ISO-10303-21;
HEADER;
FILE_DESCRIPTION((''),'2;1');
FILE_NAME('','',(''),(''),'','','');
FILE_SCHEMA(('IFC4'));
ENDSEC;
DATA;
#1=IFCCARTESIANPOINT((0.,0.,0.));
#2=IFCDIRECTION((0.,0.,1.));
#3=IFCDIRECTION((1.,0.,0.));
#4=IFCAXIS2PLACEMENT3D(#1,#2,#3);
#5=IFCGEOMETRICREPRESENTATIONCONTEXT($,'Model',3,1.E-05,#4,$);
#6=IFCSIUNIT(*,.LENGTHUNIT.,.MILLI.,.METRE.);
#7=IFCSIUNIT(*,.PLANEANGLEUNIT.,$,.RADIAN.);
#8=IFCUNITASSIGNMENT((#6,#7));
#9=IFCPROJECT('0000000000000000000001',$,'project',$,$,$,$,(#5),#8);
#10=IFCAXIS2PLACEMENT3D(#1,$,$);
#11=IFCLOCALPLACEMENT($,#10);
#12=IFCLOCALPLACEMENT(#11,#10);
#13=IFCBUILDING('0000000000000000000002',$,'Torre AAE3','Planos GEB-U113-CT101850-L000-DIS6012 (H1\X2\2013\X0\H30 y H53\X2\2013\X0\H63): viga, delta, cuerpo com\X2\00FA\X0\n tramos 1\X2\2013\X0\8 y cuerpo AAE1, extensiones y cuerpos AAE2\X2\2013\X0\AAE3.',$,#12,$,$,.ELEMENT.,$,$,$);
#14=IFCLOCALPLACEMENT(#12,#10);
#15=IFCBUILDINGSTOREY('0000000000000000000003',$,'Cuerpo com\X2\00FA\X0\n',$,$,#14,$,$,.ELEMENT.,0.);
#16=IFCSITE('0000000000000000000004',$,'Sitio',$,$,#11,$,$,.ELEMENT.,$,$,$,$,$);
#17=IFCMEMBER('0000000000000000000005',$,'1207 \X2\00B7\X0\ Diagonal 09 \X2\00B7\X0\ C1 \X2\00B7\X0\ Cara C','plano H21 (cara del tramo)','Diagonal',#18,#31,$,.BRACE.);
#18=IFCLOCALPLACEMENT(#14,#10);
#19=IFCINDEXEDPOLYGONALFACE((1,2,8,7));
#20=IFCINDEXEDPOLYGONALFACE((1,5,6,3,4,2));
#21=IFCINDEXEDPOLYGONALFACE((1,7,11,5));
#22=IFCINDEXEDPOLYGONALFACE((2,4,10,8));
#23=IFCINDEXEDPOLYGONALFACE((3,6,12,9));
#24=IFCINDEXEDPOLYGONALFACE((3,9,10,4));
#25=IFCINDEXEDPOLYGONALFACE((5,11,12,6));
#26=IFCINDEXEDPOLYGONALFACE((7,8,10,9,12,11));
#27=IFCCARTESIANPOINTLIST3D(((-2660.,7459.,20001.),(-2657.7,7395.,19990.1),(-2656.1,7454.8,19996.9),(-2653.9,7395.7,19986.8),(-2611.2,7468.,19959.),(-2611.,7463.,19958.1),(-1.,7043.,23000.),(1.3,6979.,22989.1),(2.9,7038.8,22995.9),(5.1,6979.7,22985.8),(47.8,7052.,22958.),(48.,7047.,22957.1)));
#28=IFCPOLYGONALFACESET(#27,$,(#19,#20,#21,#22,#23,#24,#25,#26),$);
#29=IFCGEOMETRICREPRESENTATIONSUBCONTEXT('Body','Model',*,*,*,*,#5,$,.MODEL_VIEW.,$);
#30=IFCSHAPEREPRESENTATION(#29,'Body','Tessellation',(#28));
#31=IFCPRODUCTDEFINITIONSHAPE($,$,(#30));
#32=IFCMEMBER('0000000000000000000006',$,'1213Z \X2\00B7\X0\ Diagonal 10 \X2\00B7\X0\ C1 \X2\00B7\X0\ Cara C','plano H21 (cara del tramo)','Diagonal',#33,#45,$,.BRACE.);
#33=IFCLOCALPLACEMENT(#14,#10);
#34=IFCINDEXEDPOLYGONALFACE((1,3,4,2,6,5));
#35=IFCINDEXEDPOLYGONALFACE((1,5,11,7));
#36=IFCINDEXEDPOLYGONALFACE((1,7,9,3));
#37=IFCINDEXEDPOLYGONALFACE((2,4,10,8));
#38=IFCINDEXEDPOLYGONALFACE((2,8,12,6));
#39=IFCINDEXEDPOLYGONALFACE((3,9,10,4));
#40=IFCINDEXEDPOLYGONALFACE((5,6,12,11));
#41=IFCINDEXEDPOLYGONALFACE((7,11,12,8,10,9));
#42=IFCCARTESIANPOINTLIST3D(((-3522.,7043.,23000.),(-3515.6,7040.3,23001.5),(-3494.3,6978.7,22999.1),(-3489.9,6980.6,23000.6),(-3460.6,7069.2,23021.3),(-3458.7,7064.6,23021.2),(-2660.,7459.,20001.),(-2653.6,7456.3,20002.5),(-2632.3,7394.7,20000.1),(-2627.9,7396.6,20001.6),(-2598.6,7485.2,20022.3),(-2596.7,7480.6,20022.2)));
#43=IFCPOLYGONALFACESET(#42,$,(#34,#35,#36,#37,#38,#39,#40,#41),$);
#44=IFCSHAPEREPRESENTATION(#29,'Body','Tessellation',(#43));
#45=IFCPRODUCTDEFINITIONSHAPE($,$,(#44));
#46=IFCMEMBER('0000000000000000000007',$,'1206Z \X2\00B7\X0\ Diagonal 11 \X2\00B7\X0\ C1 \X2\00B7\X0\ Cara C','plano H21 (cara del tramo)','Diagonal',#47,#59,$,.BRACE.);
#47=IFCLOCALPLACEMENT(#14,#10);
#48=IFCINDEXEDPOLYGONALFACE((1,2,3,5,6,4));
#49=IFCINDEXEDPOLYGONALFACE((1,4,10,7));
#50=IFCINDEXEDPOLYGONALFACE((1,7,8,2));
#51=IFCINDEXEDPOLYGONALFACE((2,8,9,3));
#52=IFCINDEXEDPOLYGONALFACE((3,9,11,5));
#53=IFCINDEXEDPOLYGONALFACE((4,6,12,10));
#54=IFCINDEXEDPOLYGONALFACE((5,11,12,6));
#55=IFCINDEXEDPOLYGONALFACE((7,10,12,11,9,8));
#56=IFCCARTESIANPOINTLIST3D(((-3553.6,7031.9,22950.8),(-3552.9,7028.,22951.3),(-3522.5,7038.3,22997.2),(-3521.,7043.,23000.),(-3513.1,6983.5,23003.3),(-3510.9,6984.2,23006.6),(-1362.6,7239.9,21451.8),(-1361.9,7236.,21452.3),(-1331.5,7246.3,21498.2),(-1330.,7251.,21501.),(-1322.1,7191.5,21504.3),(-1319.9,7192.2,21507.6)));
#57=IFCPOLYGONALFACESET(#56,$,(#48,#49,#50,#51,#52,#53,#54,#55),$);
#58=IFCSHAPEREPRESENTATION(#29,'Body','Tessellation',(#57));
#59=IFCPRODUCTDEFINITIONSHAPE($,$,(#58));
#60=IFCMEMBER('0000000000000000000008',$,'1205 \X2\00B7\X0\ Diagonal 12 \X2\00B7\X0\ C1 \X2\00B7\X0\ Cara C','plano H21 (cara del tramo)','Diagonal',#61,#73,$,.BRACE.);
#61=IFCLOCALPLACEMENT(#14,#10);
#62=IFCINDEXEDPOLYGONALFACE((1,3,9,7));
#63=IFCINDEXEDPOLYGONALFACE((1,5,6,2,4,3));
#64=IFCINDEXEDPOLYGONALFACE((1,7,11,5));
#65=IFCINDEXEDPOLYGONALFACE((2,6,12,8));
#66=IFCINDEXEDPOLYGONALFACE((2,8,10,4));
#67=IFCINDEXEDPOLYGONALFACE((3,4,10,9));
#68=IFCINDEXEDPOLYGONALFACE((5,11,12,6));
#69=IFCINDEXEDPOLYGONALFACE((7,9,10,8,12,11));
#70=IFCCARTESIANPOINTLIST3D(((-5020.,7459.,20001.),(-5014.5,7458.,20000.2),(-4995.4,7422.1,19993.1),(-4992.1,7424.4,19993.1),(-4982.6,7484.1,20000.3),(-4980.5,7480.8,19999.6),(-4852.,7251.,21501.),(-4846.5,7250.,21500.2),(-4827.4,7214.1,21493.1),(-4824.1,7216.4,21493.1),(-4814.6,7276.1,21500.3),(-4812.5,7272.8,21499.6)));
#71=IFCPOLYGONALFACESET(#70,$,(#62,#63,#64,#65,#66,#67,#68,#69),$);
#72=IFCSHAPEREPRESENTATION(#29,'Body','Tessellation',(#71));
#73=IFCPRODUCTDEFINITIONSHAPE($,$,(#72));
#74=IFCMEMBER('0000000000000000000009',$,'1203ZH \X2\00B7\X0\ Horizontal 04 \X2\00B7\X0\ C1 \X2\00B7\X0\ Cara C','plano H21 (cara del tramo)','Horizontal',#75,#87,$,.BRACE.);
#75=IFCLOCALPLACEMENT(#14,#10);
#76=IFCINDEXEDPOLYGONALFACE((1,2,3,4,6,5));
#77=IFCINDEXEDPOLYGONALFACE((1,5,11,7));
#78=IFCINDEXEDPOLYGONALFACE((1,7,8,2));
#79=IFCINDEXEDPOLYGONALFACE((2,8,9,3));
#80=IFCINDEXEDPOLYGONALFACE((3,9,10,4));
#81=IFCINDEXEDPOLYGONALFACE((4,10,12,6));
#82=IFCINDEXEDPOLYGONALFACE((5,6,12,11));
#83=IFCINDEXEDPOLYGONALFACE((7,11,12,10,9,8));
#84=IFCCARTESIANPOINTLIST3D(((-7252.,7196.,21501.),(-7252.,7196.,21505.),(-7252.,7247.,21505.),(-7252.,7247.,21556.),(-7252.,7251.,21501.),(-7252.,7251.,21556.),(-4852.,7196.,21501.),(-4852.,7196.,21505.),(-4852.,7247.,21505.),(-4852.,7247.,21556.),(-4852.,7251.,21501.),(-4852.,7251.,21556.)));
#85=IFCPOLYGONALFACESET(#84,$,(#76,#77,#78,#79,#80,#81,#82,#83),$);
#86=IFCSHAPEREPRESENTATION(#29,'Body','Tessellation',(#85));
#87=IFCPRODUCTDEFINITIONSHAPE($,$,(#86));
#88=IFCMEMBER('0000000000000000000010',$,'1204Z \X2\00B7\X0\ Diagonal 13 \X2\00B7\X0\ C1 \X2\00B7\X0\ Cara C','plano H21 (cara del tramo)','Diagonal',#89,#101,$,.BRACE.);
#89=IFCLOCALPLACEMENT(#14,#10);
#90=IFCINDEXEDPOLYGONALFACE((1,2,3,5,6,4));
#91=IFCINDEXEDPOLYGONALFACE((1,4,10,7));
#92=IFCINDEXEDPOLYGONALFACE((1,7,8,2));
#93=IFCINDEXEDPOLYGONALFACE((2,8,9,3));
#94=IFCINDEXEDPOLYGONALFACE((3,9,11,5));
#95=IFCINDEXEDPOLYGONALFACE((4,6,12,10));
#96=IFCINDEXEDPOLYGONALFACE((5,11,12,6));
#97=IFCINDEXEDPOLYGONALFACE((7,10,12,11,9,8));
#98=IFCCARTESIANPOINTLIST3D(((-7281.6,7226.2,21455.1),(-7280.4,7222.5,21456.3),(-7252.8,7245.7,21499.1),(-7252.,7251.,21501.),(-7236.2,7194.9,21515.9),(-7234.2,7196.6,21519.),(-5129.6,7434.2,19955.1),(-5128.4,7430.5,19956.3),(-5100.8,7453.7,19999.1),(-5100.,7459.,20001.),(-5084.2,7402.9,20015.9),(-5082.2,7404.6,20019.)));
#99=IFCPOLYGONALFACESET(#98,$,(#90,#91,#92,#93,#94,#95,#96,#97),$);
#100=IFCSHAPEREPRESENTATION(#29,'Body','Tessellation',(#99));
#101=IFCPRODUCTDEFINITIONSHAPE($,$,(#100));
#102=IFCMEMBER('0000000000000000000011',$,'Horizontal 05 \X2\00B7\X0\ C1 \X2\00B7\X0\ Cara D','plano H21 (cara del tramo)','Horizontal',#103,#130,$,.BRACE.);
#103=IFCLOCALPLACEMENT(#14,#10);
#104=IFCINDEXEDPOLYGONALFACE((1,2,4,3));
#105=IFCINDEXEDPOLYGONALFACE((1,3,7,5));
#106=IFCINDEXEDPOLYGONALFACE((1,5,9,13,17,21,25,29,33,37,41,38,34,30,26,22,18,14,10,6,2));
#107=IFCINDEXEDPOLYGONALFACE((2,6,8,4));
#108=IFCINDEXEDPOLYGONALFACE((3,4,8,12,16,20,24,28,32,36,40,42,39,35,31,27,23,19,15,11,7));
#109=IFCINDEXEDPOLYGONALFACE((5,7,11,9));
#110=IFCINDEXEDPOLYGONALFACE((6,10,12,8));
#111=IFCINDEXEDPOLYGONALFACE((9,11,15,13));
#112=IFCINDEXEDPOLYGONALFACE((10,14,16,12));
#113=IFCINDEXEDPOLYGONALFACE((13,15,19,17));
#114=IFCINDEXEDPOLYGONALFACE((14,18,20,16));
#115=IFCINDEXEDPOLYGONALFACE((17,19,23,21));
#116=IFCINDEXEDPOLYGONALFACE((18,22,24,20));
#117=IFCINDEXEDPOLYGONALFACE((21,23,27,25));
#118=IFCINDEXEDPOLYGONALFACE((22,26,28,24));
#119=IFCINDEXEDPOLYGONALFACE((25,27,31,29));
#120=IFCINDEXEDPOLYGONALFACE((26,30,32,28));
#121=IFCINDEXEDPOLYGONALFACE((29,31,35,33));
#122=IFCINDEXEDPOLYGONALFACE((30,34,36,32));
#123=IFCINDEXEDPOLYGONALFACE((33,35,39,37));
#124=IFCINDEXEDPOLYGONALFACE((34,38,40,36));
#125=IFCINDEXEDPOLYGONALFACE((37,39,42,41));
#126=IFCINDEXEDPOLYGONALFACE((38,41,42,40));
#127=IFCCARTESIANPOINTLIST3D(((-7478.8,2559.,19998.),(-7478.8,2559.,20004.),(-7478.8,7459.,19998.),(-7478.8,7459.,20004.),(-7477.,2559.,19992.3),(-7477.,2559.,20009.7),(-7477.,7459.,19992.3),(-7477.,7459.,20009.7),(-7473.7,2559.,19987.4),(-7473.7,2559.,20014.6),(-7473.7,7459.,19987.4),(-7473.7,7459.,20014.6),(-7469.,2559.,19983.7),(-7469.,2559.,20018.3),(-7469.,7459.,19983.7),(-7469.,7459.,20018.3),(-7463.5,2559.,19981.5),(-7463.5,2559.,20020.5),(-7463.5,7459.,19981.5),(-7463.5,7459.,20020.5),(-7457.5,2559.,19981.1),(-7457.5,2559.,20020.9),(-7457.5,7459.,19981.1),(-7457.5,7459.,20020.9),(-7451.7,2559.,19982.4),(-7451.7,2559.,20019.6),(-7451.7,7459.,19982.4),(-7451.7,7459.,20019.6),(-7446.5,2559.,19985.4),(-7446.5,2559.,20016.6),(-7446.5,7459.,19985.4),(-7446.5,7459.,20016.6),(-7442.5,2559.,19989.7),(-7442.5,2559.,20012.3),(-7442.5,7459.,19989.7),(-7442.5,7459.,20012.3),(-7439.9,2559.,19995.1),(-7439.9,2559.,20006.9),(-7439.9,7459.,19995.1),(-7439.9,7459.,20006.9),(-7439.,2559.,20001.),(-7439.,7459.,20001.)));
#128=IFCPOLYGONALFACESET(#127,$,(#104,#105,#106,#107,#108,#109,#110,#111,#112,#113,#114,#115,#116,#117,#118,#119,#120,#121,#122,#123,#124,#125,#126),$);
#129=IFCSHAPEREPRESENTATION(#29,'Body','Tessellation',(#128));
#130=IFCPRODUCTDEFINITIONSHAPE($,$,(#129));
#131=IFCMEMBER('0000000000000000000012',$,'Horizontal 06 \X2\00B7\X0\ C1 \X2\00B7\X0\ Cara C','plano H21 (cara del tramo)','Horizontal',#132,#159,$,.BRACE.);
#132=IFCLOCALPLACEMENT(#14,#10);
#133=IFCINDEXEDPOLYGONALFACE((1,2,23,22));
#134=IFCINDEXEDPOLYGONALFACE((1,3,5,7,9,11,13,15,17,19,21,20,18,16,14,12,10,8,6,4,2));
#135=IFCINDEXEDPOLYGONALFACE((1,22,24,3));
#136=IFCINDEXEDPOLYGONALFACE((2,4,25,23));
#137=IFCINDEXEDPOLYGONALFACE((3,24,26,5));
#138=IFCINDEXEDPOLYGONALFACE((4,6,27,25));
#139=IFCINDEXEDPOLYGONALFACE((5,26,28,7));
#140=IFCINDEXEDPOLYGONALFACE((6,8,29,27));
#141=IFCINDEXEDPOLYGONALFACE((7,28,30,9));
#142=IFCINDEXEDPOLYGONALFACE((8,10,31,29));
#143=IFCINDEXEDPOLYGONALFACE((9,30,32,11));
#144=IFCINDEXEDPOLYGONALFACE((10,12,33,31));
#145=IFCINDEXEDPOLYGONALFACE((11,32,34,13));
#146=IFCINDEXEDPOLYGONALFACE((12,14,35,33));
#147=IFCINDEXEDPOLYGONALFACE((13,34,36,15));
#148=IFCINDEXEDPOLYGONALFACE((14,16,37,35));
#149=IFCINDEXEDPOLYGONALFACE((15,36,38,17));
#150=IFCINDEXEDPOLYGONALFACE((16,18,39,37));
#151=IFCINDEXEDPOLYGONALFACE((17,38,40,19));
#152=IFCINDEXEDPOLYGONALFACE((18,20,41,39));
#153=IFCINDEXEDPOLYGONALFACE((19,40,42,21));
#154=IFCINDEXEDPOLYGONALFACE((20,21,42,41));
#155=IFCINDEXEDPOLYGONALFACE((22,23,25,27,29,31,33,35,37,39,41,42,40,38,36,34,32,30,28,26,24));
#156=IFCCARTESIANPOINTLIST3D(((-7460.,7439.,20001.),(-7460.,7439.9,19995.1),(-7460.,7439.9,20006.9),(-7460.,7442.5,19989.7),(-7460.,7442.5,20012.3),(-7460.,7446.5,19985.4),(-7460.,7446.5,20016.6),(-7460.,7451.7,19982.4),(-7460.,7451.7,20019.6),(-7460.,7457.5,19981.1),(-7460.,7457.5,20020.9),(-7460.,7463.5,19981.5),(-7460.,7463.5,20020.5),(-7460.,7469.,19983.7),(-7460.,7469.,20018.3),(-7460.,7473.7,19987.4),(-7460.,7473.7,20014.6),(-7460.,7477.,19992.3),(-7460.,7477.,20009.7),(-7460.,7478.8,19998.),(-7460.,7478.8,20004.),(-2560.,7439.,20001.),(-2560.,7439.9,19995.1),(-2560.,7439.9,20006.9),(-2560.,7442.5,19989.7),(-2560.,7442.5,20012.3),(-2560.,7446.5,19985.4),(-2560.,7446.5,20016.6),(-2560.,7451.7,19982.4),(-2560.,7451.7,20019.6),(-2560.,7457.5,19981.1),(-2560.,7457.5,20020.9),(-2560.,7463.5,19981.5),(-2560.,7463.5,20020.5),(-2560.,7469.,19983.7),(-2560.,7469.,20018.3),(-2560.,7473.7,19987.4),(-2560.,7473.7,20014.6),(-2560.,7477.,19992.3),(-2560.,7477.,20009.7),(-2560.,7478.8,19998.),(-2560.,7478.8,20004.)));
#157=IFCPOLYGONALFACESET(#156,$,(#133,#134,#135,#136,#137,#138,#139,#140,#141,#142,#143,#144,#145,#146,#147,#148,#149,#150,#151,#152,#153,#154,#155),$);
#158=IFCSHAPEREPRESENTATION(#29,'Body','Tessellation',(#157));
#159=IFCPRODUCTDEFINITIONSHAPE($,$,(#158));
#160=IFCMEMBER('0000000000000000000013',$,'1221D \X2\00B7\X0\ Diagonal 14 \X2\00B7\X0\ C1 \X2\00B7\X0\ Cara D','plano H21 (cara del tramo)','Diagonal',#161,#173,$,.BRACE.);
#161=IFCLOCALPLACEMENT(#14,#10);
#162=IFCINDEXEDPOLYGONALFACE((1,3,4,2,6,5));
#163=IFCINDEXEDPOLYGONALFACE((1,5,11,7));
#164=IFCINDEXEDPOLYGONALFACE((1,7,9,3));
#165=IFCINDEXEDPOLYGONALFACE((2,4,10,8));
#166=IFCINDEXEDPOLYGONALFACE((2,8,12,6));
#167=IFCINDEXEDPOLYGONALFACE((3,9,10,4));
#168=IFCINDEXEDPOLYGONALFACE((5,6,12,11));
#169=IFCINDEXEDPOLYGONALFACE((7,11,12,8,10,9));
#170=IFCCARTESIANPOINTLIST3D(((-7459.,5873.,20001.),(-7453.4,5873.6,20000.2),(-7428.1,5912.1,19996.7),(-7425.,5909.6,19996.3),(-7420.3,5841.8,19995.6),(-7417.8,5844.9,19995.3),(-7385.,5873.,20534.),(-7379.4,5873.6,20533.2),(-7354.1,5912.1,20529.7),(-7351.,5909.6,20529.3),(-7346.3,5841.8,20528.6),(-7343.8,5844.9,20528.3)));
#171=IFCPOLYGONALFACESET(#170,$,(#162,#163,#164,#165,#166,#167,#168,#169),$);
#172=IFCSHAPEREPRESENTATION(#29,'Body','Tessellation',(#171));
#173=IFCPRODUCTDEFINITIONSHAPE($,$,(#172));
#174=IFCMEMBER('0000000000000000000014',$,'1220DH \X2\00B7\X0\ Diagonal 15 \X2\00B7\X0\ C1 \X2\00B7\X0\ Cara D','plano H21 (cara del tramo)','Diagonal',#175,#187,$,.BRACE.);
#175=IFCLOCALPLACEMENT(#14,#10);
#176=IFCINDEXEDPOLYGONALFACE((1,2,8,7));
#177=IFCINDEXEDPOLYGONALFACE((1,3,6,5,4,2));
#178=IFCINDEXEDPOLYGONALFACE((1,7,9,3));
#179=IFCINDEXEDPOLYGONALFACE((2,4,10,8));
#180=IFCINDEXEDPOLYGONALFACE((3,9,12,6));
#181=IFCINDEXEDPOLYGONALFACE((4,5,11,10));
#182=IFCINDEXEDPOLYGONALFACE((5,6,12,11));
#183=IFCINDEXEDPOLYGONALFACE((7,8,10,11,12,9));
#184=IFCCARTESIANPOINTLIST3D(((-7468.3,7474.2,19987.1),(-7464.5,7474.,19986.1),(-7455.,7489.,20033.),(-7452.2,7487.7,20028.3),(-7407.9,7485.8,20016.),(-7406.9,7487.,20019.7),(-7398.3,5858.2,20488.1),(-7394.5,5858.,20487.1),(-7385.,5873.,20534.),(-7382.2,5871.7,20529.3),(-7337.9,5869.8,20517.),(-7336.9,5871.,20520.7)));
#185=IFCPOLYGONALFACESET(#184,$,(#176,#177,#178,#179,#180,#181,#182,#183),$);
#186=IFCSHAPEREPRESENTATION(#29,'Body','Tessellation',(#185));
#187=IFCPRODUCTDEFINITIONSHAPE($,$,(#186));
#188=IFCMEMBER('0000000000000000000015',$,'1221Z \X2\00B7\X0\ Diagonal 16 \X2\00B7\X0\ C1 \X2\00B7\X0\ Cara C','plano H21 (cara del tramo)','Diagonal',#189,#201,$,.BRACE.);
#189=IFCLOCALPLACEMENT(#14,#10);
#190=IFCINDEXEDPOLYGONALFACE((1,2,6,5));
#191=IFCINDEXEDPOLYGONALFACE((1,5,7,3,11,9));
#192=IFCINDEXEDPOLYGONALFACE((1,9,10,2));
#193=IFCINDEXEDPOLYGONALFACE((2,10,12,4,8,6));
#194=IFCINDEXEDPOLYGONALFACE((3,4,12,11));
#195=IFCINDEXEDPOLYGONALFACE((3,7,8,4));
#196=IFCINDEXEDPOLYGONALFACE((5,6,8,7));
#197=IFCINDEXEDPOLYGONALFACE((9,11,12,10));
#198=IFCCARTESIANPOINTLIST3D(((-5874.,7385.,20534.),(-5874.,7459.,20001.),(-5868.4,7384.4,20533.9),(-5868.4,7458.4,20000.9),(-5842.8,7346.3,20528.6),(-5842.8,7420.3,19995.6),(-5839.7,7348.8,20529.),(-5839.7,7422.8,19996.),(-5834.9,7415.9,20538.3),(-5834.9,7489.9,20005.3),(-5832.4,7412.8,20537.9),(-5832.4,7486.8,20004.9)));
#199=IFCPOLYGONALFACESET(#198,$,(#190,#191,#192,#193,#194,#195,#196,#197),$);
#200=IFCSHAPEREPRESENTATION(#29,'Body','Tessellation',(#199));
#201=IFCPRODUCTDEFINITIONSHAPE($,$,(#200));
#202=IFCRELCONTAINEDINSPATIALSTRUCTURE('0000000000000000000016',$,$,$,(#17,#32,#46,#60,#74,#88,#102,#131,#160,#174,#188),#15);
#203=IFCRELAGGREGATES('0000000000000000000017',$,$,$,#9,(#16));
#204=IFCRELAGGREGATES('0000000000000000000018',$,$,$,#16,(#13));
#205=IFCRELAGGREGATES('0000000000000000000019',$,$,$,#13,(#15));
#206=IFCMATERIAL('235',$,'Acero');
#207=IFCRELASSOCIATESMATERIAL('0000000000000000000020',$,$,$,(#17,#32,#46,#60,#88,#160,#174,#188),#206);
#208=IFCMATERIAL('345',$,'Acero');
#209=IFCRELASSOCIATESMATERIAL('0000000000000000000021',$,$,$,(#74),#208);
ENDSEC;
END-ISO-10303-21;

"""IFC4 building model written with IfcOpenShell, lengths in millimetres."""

from ifc_helpers import new_model, si_unit, frame, frame_2d, origin, origin_with_axes, place, context, subcontext, project, spatial, circle, l_section, extrude, material, element, save


model = new_model("IFC4")

# Units and contexts
model_context = context("Model", 3, precision=1e-05, world=origin_with_axes())
body_context = subcontext(model_context, "Body", "Model", "MODEL_VIEW")
ifc_project = project(units=[si_unit("LENGTHUNIT", "METRE", prefix="MILLI"), si_unit("PLANEANGLEUNIT", "RADIAN")], contexts=[model_context])

# Site, building, storey
site_placement = place(None, origin())
site = spatial("IfcSite", under=ifc_project, at=site_placement, Name="Sitio", CompositionType="ELEMENT")
building_placement = place(site_placement, origin())
building = spatial("IfcBuilding", under=site, at=building_placement, Name="Torre AAE3", Description="Planos GEB-U113-CT101850-L000-DIS6012 (H1–H30 y H53–H63): viga, delta, cuerpo común tramos 1–8 y cuerpo AAE1, extensiones y cuerpos AAE2–AAE3.", CompositionType="ELEMENT")
storey_placement = place(building_placement, origin())
storey = spatial("IfcBuildingStorey", under=building, at=storey_placement, Name="Cuerpo común", CompositionType="ELEMENT", Elevation=0.0)

# Members
ifc_material_1 = material(Name="345", Category="Acero")
ifc_material_2 = material(Name="235", Category="Acero")
member_1_placement = place(storey_placement, frame((-2660.0, 7459.0, 20001.0), z_axis=(0.659874, -0.103237, 0.74425), x_axis=(0.035769, -0.985077, -0.168357)))
element("IfcMember", 1, at=member_1_placement, inside=storey, material=ifc_material_2, Name="1207 · Diagonal 09 · C1 · Cara C", Description="plano H21 (cara del tramo)", ObjectType="Diagonal", PredefinedType="BRACE", context=body_context, shape_type="SweptSolid", body=[
    extrude(l_section(Depth=65.0, Width=65.0, Thickness=5.0, at=frame_2d((32.5, 32.5))), None, (0.0, 0.0, 1.0), 4029.6),
])
member_2_placement = place(storey_placement, frame((-2660.0, 7459.0, 20001.0), z_axis=(-0.273822, -0.132146, 0.952659), x_axis=(0.396066, -0.918122, -0.013514)))
element("IfcMember", 2, at=member_2_placement, inside=storey, material=ifc_material_2, Name="1213Z · Diagonal 10 · C1 · Cara C", Description="plano H21 (cara del tramo)", ObjectType="Diagonal", PredefinedType="BRACE", context=body_context, shape_type="SweptSolid", body=[
    extrude(l_section(Depth=70.0, Width=70.0, Thickness=5.0, at=frame_2d((35.0, 35.0))), None, (0.0, 0.0, 1.0), 3148.0),
])
member_3_placement = place(storey_placement, frame((-3521.0, 7043.0, 23000.0), z_axis=(0.822804, 0.078112, -0.562932), x_axis=(0.167732, -0.979764, 0.109213)))
element("IfcMember", 3, at=member_3_placement, inside=storey, material=ifc_material_2, Name="1206Z · Diagonal 11 · C1 · Cara C", Description="plano H21 (cara del tramo)", ObjectType="Diagonal", PredefinedType="BRACE", context=body_context, shape_type="SweptSolid", body=[
    extrude(l_section(Depth=60.0, Width=60.0, Thickness=4.0, at=frame_2d((30.0, 30.0))), None, (0.0, 0.0, 1.0), 2662.8),
])
member_4_placement = place(storey_placement, frame((-5020.0, 7459.0, 20001.0), z_axis=(0.110262, -0.136515, 0.984483), x_axis=(0.546389, -0.819092, -0.174776)))
element("IfcMember", 4, at=member_4_placement, inside=storey, material=ifc_material_2, Name="1205 · Diagonal 12 · C1 · Cara C", Description="plano H21 (cara del tramo)", ObjectType="Diagonal", PredefinedType="BRACE", context=body_context, shape_type="SweptSolid", body=[
    extrude(l_section(Depth=45.0, Width=45.0, Thickness=4.0, at=frame_2d((22.5, 22.5))), None, (0.0, 0.0, 1.0), 1523.6),
])
member_5_placement = place(storey_placement, frame((-4852.0, 7251.0, 21501.0), z_axis=(-1.0, 0.0, 0.0), x_axis=(0.0, -1.0, 0.0)))
element("IfcMember", 5, at=member_5_placement, inside=storey, material=ifc_material_1, Name="1203ZH · Horizontal 04 · C1 · Cara C", Description="plano H21 (cara del tramo)", ObjectType="Horizontal", PredefinedType="BRACE", context=body_context, shape_type="SweptSolid", body=[
    extrude(l_section(Depth=55.0, Width=55.0, Thickness=4.0, at=frame_2d((27.5, 27.5))), None, (0.0, 0.0, 1.0), 2400.0),
])
member_6_placement = place(storey_placement, frame((-7252.0, 7251.0, 21501.0), z_axis=(0.81781, 0.079045, -0.570035), x_axis=(0.296545, -0.906773, 0.299704)))
element("IfcMember", 6, at=member_6_placement, inside=storey, material=ifc_material_2, Name="1204Z · Diagonal 13 · C1 · Cara C", Description="plano H21 (cara del tramo)", ObjectType="Diagonal", PredefinedType="BRACE", context=body_context, shape_type="SweptSolid", body=[
    extrude(l_section(Depth=60.0, Width=60.0, Thickness=4.0, at=frame_2d((30.0, 30.0))), None, (0.0, 0.0, 1.0), 2631.4),
])
for number, where, z_axis, x_axis, name in (
    (7, (-7459.0, 7459.0, 20001.0), (0.0, -1.0, 0.0), (1.0, 0.0, 0.0), "Horizontal 05 · C1 · Cara D"),
    (8, (-7460.0, 7459.0, 20001.0), (1.0, 0.0, 0.0), (0.0, -1.0, 0.0), "Horizontal 06 · C1 · Cara C"),
):
    element("IfcMember", number, at=place(storey_placement, frame(where, z_axis=z_axis, x_axis=x_axis)), inside=storey, Name=name, Description="plano H21 (cara del tramo)", ObjectType="Horizontal", PredefinedType="BRACE", context=body_context, shape_type="SweptSolid", body=[
        extrude(circle(Radius=20.0), None, (0.0, 0.0, 1.0), 4900.0),
    ])
member_7_placement = place(storey_placement, frame((-7459.0, 5873.0, 20001.0), z_axis=(0.137518, 0.0, 0.990499), x_axis=(0.77387, -0.624164, -0.107442)))
element("IfcMember", 9, at=member_7_placement, inside=storey, material=ifc_material_2, Name="1221D · Diagonal 14 · C1 · Cara D", Description="plano H21 (cara del tramo)", ObjectType="Diagonal", PredefinedType="BRACE", context=body_context, shape_type="SweptSolid", body=[
    extrude(l_section(Depth=50.0, Width=50.0, Thickness=4.0, at=frame_2d((25.0, 25.0))), None, (0.0, 0.0, 1.0), 538.1),
])
member_8_placement = place(storey_placement, frame((-7385.0, 5873.0, 20534.0), z_axis=(-0.041339, 0.954334, -0.295867), x_axis=(0.962961, -0.040915, -0.266519)))
element("IfcMember", 10, at=member_8_placement, inside=storey, material=ifc_material_2, Name="1220DH · Diagonal 15 · C1 · Cara D", Description="plano H21 (cara del tramo)", ObjectType="Diagonal", PredefinedType="BRACE", context=body_context, shape_type="SweptSolid", body=[
    extrude(l_section(Depth=50.0, Width=50.0, Thickness=4.0, at=frame_2d((25.0, 25.0))), None, (0.0, 0.0, 1.0), 1693.3),
])
member_9_placement = place(storey_placement, frame((-5874.0, 7459.0, 20001.0), z_axis=(0.0, -0.137518, 0.990499), x_axis=(0.624229, -0.773819, -0.107435)))
element("IfcMember", 11, at=member_9_placement, inside=storey, material=ifc_material_2, Name="1221Z · Diagonal 16 · C1 · Cara C", Description="plano H21 (cara del tramo)", ObjectType="Diagonal", PredefinedType="BRACE", context=body_context, shape_type="SweptSolid", body=[
    extrude(l_section(Depth=50.0, Width=50.0, Thickness=4.0, at=frame_2d((25.0, 25.0))), None, (0.0, 0.0, 1.0), 538.1),
])

save(model, "model.ifc")
